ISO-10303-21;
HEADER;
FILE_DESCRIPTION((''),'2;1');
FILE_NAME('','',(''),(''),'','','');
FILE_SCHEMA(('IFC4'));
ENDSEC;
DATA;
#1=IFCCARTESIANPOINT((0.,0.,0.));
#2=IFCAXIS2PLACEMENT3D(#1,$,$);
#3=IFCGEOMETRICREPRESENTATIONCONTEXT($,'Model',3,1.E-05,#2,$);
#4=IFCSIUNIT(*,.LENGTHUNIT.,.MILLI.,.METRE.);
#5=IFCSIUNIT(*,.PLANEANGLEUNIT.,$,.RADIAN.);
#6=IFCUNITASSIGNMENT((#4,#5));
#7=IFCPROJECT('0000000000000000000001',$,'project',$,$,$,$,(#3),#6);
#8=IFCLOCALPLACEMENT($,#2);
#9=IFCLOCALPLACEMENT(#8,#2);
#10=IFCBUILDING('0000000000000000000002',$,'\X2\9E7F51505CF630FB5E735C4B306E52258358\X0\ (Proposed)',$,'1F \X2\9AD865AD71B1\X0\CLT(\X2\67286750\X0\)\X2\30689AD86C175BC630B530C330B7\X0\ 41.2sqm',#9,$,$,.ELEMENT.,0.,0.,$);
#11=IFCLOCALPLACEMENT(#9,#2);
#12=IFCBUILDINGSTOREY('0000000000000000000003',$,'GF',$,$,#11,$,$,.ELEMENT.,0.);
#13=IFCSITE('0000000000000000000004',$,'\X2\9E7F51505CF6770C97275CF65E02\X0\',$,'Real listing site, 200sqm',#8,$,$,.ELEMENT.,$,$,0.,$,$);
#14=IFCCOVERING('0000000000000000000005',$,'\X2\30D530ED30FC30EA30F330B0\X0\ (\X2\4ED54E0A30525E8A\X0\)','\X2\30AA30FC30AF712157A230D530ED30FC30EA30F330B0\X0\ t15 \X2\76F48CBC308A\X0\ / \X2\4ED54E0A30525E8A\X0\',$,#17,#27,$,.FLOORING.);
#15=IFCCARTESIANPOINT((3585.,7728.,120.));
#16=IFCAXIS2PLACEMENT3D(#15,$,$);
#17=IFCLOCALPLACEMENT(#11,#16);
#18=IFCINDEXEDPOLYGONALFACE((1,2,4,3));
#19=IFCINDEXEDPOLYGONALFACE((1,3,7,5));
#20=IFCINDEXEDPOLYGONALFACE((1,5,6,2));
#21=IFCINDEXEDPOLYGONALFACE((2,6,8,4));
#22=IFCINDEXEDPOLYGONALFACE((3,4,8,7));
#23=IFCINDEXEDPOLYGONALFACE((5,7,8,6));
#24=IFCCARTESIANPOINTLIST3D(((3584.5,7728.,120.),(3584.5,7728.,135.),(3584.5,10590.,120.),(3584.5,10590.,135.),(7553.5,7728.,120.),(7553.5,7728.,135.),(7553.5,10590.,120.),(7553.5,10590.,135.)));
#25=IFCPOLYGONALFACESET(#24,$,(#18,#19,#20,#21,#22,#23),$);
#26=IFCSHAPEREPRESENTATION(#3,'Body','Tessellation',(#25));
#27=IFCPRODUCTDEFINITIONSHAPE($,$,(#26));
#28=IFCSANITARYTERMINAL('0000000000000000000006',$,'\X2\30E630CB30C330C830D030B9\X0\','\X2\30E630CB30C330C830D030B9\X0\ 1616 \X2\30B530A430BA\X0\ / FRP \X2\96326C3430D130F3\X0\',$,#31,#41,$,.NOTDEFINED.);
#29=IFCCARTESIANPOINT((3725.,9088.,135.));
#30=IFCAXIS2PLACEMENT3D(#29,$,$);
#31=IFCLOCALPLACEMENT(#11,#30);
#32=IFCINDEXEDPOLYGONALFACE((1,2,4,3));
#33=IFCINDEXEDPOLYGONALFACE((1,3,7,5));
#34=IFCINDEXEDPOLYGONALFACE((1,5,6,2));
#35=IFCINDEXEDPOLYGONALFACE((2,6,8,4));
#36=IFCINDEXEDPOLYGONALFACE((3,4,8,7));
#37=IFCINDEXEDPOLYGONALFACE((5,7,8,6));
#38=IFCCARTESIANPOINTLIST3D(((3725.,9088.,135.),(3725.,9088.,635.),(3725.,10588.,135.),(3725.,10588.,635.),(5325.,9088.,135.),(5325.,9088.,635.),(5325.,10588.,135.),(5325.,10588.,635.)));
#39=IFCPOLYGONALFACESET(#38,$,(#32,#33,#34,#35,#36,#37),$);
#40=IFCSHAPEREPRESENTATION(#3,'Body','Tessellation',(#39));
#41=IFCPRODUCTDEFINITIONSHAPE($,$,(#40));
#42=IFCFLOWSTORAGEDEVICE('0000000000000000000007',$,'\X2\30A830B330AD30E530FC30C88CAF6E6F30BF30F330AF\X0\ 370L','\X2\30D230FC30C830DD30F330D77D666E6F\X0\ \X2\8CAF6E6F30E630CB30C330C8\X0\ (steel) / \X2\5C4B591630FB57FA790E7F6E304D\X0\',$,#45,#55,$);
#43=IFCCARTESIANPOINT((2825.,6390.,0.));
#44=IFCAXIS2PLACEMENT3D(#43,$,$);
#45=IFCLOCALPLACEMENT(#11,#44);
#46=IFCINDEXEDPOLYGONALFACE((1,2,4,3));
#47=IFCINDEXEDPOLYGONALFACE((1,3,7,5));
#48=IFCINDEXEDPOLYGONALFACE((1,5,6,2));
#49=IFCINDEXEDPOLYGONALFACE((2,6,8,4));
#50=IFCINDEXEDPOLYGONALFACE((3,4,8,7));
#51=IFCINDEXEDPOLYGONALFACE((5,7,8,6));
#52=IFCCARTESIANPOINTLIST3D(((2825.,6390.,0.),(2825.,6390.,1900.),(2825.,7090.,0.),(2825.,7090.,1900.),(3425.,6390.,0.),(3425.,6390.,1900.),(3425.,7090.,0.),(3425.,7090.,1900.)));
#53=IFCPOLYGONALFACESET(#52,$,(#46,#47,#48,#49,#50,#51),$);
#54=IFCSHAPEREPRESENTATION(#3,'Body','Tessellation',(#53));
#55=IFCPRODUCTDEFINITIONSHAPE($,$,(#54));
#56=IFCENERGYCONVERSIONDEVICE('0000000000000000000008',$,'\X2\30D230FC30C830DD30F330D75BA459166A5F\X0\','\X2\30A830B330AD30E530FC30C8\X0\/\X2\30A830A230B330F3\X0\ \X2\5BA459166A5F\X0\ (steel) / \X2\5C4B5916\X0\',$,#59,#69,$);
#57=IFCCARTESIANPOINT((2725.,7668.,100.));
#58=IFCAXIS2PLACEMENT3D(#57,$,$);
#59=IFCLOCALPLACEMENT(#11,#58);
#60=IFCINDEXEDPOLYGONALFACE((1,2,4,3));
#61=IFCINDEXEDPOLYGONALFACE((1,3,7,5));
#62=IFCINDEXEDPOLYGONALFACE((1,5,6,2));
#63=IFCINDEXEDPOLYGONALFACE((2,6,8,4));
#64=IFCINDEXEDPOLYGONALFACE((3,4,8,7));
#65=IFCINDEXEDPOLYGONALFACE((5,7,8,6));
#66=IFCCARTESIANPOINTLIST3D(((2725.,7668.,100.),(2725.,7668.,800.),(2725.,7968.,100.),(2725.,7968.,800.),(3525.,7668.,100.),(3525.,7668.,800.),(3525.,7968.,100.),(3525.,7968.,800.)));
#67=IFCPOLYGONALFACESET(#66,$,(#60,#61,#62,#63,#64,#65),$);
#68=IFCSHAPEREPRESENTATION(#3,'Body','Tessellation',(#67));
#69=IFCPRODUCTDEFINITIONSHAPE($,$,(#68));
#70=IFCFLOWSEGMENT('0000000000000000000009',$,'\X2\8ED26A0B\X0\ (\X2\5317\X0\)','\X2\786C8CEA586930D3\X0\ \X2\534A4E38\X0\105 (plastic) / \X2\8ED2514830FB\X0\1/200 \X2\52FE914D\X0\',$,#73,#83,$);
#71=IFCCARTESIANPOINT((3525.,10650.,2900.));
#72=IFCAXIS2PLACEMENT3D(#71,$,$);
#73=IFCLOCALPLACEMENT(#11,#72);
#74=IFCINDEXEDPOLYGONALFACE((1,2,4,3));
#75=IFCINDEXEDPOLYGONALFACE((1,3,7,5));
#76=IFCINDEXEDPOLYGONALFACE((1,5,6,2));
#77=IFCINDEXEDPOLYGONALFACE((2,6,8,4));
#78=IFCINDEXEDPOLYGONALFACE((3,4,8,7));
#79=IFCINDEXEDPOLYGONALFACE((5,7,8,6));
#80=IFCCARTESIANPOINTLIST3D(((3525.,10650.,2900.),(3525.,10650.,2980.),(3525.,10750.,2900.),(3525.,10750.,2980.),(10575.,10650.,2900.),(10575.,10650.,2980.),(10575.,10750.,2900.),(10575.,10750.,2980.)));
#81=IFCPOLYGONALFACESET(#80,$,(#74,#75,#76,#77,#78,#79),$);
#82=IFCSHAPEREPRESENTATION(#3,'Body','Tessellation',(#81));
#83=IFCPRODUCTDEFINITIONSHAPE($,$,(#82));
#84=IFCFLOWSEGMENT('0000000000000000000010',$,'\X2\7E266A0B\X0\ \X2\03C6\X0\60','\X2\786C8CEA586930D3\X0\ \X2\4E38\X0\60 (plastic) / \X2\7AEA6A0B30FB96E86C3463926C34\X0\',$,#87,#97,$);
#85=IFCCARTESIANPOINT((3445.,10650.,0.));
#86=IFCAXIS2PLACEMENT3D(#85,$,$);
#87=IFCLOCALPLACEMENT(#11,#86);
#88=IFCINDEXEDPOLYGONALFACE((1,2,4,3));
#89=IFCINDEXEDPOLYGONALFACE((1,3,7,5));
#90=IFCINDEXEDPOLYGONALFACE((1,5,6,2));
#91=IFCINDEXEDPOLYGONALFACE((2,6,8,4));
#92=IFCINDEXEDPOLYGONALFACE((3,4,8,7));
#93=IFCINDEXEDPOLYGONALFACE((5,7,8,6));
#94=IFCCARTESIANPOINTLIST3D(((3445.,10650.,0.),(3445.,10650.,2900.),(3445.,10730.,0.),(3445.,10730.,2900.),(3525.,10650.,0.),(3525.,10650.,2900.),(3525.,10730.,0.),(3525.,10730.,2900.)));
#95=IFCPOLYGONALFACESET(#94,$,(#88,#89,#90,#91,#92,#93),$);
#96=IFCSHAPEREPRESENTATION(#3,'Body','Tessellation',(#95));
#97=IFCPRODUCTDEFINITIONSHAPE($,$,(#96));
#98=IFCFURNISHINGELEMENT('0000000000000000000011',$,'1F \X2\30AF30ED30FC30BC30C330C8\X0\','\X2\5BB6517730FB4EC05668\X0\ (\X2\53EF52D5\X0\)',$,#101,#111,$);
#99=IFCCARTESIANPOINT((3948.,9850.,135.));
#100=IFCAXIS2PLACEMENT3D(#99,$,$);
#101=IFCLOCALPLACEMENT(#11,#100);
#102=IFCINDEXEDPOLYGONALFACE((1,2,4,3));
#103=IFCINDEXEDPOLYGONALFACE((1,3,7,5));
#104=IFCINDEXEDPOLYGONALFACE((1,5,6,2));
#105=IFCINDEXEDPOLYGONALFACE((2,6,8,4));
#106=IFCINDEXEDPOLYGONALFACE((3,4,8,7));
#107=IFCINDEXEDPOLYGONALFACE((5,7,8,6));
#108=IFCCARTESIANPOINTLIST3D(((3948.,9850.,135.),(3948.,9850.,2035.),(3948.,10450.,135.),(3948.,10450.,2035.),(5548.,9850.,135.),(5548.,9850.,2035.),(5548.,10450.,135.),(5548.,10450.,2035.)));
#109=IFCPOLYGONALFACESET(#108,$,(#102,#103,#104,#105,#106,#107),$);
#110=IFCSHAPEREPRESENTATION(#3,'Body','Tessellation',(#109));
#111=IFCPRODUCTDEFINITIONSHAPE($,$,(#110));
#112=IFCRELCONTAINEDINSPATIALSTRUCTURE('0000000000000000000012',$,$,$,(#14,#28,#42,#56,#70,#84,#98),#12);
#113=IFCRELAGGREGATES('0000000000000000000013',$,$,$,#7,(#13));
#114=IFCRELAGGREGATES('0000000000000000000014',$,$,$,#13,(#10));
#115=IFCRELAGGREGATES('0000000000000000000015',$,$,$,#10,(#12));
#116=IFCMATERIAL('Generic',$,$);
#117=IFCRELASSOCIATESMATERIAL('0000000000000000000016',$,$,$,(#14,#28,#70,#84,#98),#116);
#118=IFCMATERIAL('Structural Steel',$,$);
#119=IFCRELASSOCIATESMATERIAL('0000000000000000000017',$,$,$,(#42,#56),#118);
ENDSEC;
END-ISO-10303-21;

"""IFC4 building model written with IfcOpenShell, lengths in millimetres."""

from ifc_helpers import new_model, si_unit, frame, frame_2d, origin, place, context, project, spatial, rectangle, extrude, material, element, save


model = new_model("IFC4")

# Units and contexts
model_context = context("Model", 3, precision=1e-05, world=origin())
ifc_project = project(units=[si_unit("LENGTHUNIT", "METRE", prefix="MILLI"), si_unit("PLANEANGLEUNIT", "RADIAN")], contexts=[model_context])

# Site, building, storey
site_placement = place(None, origin())
site = spatial("IfcSite", under=ifc_project, at=site_placement, Name="鹿児島県霧島市", ObjectType="Real listing site, 200sqm", CompositionType="ELEMENT", RefElevation=0.0)
building_placement = place(site_placement, origin())
building = spatial("IfcBuilding", under=site, at=building_placement, Name="鹿児島・平屋の別荘 (Proposed)", ObjectType="1F 高断熱CLT(木材)と高気密サッシ 41.2sqm", CompositionType="ELEMENT", ElevationOfRefHeight=0.0, ElevationOfTerrain=0.0)
storey_placement = place(building_placement, origin())
storey = spatial("IfcBuildingStorey", under=building, at=storey_placement, Name="GF", CompositionType="ELEMENT", Elevation=0.0)

# Shared definitions
ifc_material_1 = material(Name="Structural Steel")

# Covering
ifc_material_2 = material(Name="Generic")
covering_placement = place(storey_placement, frame((3585.0, 7728.0, 120.0)))
element("IfcCovering", 1, at=covering_placement, inside=storey, material=ifc_material_2, Name="フローリング (仕上げ床)", Description="オーク無垢フローリング t15 直貼り / 仕上げ床", PredefinedType="FLOORING", context=model_context, shape_type="SweptSolid", body=[
    extrude(rectangle(XDim=3969.0, YDim=2862.0, at=frame_2d((1984.0, 1431.0))), frame((3585.0, 7728.0, 120.0)), (0.0, 0.0, 1.0), 15.0),
])

# Sanitary terminal
sanitary_terminal_placement = place(storey_placement, frame((3725.0, 9088.0, 135.0)))
element("IfcSanitaryTerminal", 2, at=sanitary_terminal_placement, inside=storey, material=ifc_material_2, Name="ユニットバス", Description="ユニットバス 1616 サイズ / FRP 防水パン", PredefinedType="NOTDEFINED", context=model_context, shape_type="SweptSolid", body=[
    extrude(rectangle(XDim=1600.0, YDim=1500.0, at=frame_2d((800.0, 750.0))), frame((3725.0, 9088.0, 135.0)), (0.0, 0.0, 1.0), 500.0),
])

# Flow storage device
flow_storage_device_placement = place(storey_placement, frame((2825.0, 6390.0, 0.0)))
element("IfcFlowStorageDevice", 3, at=flow_storage_device_placement, inside=storey, material=ifc_material_1, Name="エコキュート貯湯タンク 370L", Description="ヒートポンプ給湯 貯湯ユニット (steel) / 屋外・基礎置き", context=model_context, shape_type="SweptSolid", body=[
    extrude(rectangle(XDim=600.0, YDim=700.0, at=frame_2d((300.0, 350.0))), frame((2825.0, 6390.0, 0.0)), (0.0, 0.0, 1.0), 1900.0),
])

# Energy conversion device
energy_conversion_device_placement = place(storey_placement, frame((2725.0, 7668.0, 100.0)))
element("IfcEnergyConversionDevice", 4, at=energy_conversion_device_placement, inside=storey, material=ifc_material_1, Name="ヒートポンプ室外機", Description="エコキュート/エアコン 室外機 (steel) / 屋外", context=model_context, shape_type="SweptSolid", body=[
    extrude(rectangle(XDim=800.0, YDim=300.0, at=frame_2d((400.0, 150.0))), frame((2725.0, 7668.0, 100.0)), (0.0, 0.0, 1.0), 700.0),
])

# Flow segments
flow_segment_1_placement = place(storey_placement, frame((3525.0, 10650.0, 2900.0)))
element("IfcFlowSegment", 5, at=flow_segment_1_placement, inside=storey, material=ifc_material_2, Name="軒樋 (北)", Description="硬質塩ビ 半丸105 (plastic) / 軒先・1/200 勾配", context=model_context, shape_type="SweptSolid", body=[
    extrude(rectangle(XDim=7050.0, YDim=100.0, at=frame_2d((3525.0, 50.0))), frame((3525.0, 10650.0, 2900.0)), (0.0, 0.0, 1.0), 80.0),
])
flow_segment_2_placement = place(storey_placement, frame((3445.0, 10650.0, 0.0)))
element("IfcFlowSegment", 6, at=flow_segment_2_placement, inside=storey, material=ifc_material_2, Name="縦樋 φ60", Description="硬質塩ビ 丸60 (plastic) / 竪樋・雨水排水", context=model_context, shape_type="SweptSolid", body=[
    extrude(rectangle(XDim=80.0, YDim=80.0, at=frame_2d((40.0, 40.0))), frame((3445.0, 10650.0, 0.0)), (0.0, 0.0, 1.0), 2900.0),
])

# Furnishing element
furnishing_placement = place(storey_placement, frame((3948.0, 9850.0, 135.0)))
element("IfcFurnishingElement", 7, at=furnishing_placement, inside=storey, material=ifc_material_2, Name="1F クローゼット", Description="家具・什器 (可動)", context=model_context, shape_type="SweptSolid", body=[
    extrude(rectangle(XDim=1600.0, YDim=600.0, at=frame_2d((800.0, 300.0))), frame((3948.0, 9850.0, 135.0)), (0.0, 0.0, 1.0), 1900.0),
])

save(model, "model.ifc")
